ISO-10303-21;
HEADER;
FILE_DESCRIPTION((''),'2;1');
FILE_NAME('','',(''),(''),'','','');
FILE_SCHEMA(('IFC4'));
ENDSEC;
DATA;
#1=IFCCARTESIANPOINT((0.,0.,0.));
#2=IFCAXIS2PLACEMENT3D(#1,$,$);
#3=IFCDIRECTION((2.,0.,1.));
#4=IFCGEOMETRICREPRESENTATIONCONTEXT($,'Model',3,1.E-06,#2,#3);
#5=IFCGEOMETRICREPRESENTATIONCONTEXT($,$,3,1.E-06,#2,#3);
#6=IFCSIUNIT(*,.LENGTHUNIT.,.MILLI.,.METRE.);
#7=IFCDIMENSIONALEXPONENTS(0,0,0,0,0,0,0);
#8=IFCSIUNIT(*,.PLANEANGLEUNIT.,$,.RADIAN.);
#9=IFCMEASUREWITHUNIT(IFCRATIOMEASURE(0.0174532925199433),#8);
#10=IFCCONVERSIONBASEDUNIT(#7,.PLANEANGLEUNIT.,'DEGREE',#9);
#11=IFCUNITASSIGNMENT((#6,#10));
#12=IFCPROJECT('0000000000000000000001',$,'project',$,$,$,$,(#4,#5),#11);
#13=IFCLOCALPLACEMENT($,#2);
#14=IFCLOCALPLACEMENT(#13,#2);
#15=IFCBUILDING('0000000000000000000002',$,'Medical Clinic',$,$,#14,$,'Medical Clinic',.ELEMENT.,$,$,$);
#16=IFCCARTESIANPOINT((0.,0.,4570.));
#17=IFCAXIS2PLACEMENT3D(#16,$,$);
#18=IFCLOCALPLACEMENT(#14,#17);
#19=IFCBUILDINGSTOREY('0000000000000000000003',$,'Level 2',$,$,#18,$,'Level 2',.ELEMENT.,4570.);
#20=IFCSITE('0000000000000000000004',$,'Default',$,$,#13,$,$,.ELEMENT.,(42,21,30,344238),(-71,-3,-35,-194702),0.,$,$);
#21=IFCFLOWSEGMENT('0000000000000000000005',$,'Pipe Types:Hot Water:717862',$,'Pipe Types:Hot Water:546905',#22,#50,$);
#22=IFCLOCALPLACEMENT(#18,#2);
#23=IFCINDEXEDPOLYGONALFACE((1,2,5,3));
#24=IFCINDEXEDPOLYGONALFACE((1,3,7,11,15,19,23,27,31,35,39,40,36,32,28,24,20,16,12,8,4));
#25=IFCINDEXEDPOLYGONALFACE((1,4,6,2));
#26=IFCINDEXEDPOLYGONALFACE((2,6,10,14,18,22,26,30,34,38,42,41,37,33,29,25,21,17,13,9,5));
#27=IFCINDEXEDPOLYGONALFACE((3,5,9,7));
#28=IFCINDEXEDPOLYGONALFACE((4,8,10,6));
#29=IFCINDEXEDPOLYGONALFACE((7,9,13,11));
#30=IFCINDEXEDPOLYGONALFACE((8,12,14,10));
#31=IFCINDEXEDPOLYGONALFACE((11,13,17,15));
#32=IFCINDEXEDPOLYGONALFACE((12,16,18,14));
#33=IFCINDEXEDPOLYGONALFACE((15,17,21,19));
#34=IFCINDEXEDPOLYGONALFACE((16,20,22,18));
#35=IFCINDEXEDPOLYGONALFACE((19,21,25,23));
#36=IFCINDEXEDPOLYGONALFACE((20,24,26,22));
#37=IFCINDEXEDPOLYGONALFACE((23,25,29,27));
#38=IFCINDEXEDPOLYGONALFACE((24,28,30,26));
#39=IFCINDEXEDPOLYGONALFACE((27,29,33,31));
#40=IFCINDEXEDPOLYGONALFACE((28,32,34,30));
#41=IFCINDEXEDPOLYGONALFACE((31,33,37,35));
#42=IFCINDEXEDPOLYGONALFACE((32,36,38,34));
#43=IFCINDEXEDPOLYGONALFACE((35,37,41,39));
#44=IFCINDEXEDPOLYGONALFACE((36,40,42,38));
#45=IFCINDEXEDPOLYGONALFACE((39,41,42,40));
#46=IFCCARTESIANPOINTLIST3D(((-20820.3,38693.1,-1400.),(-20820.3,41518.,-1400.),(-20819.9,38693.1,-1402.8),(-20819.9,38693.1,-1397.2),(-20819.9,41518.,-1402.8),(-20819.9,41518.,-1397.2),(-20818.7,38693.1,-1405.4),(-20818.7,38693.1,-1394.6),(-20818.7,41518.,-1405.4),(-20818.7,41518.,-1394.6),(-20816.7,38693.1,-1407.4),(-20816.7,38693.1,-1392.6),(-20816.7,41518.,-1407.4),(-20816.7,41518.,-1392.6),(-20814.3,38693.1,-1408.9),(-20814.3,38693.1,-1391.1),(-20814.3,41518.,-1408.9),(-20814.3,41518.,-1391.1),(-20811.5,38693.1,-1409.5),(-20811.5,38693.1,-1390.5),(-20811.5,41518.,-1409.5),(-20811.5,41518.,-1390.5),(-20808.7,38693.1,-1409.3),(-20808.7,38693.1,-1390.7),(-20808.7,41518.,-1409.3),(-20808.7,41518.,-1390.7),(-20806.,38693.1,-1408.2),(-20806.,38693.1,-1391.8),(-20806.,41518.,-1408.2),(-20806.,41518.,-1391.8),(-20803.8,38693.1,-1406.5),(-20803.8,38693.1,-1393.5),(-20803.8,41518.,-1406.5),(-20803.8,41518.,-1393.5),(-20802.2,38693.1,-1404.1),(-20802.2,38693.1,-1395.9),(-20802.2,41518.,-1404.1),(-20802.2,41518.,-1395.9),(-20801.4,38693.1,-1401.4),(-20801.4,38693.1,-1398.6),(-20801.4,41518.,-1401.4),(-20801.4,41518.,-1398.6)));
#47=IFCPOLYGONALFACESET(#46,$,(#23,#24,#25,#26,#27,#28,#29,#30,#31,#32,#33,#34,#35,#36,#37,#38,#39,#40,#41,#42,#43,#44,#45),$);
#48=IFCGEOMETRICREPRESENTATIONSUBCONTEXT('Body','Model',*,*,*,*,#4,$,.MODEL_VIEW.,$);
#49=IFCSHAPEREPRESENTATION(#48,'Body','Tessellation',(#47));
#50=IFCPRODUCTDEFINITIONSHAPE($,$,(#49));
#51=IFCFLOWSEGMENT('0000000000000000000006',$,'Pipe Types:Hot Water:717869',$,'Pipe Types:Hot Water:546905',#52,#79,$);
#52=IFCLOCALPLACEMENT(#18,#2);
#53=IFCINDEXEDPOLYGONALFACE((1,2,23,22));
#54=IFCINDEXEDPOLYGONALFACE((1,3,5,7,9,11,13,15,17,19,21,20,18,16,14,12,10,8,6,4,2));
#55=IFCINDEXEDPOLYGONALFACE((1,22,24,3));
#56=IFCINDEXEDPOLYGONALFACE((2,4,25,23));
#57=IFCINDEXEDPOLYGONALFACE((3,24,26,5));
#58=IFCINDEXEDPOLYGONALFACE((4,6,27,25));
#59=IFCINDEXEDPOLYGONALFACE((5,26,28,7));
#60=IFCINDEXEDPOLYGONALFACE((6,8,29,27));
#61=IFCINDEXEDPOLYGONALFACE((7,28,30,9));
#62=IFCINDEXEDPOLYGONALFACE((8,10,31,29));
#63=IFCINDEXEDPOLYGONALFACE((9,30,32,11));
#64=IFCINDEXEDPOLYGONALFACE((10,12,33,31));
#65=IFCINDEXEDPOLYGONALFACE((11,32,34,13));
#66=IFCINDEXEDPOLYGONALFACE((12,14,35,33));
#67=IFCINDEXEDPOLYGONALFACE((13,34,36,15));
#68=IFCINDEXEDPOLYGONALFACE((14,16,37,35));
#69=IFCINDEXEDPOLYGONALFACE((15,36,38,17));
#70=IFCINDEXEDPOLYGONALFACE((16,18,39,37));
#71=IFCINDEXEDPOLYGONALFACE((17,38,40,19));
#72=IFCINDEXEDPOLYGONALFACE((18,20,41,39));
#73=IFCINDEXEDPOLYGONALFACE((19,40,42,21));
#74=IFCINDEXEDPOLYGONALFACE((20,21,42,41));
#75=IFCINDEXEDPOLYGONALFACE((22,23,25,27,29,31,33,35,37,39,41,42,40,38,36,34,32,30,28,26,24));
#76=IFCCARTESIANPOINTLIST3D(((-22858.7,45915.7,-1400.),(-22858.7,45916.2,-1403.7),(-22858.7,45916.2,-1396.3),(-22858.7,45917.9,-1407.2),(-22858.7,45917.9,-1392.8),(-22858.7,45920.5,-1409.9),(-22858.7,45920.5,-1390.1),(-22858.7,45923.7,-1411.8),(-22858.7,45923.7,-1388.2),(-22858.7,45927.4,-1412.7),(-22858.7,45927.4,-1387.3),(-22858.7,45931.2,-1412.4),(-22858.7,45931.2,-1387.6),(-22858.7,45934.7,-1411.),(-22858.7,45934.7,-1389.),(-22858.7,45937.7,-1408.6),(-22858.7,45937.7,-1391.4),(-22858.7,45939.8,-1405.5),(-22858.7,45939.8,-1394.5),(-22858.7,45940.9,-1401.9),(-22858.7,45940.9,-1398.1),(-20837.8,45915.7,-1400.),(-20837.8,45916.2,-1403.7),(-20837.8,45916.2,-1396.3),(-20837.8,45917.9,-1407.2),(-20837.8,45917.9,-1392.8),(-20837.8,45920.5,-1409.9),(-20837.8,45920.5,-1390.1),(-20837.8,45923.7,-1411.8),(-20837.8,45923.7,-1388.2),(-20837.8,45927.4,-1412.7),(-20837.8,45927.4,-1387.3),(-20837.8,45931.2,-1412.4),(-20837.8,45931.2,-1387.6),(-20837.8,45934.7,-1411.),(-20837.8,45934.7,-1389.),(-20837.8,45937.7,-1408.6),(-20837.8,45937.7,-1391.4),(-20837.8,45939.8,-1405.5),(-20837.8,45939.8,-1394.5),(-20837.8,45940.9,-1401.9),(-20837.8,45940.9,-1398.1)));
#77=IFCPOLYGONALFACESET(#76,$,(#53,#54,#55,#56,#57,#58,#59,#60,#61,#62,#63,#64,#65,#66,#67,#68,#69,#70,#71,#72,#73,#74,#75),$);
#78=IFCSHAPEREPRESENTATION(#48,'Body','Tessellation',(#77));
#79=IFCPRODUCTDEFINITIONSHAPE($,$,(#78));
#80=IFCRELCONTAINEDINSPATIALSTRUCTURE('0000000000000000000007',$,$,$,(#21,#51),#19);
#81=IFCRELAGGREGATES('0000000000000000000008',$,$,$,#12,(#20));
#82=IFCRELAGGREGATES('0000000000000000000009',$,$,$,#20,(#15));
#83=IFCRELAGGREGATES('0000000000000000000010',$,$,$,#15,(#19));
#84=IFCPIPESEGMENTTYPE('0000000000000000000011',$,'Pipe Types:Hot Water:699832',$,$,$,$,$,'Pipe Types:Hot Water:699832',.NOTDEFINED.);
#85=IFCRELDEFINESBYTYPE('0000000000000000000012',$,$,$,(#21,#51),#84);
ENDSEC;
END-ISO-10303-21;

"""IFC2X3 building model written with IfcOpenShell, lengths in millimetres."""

from ifc_helpers import new_model, entity, si_unit, converted_unit, direction, frame, origin, origin_2d_with_axis, place, context, subcontext, project, spatial, circle, extrude, type_object, element, save


model = new_model("IFC2X3")

# Units and contexts
model_context = context("Model", 3, precision=1e-06, world=origin(), true_north=direction((2.0, 0.0, 1.0)))
context_of_model = context(None, 3, precision=1e-06, world=origin(), true_north=direction((2.0, 0.0, 1.0)))
body_context = subcontext(model_context, "Body", "Model", "MODEL_VIEW")
ifc_project = project(units=[si_unit("LENGTHUNIT", "METRE", prefix="MILLI"), converted_unit("PLANEANGLEUNIT", "DEGREE", entity("IfcRatioMeasure", 0.0174532925199433), si_unit("PLANEANGLEUNIT", "RADIAN"), dimensions=[0, 0, 0, 0, 0, 0, 0])], contexts=[model_context, context_of_model])

# Site, building, storey
site_placement = place(None, origin())
site = spatial("IfcSite", under=ifc_project, at=site_placement, Name="Default", CompositionType="ELEMENT", RefLatitude=(42, 21, 30, 344238), RefLongitude=(-71, -3, -35, -194702), RefElevation=0.0)
building_placement = place(site_placement, origin())
building = spatial("IfcBuilding", under=site, at=building_placement, Name="Medical Clinic", LongName="Medical Clinic", CompositionType="ELEMENT")
storey_placement = place(building_placement, frame((0.0, 0.0, 4570.0)))
storey = spatial("IfcBuildingStorey", under=building, at=storey_placement, Name="Level 2", LongName="Level 2", CompositionType="ELEMENT", Elevation=4570.0)

# Flow segments
pipe_segment_type = type_object("IfcPipeSegmentType", Name="Pipe Types:Hot Water:699832", ElementType="Pipe Types:Hot Water:699832", PredefinedType="NOTDEFINED")
flow_segment_1_placement = place(storey_placement, origin())
element("IfcFlowSegment", 1, at=flow_segment_1_placement, inside=storey, type_object=pipe_segment_type, Name="Pipe Types:Hot Water:717862", ObjectType="Pipe Types:Hot Water:546905", context=body_context, shape_type="SweptSolid", body=[
    extrude(circle(Radius=9.5, at=origin_2d_with_axis()), frame((-20810.8, 38693.1, -1400.0), z_axis=(0.0, 1.0, 0.0), x_axis=(-1.0, 0.0, 0.0)), (0.0, 0.0, 1.0), 2824.9),
])
flow_segment_2_placement = place(storey_placement, origin())
element("IfcFlowSegment", 2, at=flow_segment_2_placement, inside=storey, type_object=pipe_segment_type, Name="Pipe Types:Hot Water:717869", ObjectType="Pipe Types:Hot Water:546905", context=body_context, shape_type="SweptSolid", body=[
    extrude(circle(Radius=12.7, at=origin_2d_with_axis()), frame((-22858.7, 45928.4, -1400.0), z_axis=(1.0, 0.0, 0.0), x_axis=(0.0, -1.0, 0.0)), (0.0, 0.0, 1.0), 2020.9),
])

save(model, "model.ifc")
